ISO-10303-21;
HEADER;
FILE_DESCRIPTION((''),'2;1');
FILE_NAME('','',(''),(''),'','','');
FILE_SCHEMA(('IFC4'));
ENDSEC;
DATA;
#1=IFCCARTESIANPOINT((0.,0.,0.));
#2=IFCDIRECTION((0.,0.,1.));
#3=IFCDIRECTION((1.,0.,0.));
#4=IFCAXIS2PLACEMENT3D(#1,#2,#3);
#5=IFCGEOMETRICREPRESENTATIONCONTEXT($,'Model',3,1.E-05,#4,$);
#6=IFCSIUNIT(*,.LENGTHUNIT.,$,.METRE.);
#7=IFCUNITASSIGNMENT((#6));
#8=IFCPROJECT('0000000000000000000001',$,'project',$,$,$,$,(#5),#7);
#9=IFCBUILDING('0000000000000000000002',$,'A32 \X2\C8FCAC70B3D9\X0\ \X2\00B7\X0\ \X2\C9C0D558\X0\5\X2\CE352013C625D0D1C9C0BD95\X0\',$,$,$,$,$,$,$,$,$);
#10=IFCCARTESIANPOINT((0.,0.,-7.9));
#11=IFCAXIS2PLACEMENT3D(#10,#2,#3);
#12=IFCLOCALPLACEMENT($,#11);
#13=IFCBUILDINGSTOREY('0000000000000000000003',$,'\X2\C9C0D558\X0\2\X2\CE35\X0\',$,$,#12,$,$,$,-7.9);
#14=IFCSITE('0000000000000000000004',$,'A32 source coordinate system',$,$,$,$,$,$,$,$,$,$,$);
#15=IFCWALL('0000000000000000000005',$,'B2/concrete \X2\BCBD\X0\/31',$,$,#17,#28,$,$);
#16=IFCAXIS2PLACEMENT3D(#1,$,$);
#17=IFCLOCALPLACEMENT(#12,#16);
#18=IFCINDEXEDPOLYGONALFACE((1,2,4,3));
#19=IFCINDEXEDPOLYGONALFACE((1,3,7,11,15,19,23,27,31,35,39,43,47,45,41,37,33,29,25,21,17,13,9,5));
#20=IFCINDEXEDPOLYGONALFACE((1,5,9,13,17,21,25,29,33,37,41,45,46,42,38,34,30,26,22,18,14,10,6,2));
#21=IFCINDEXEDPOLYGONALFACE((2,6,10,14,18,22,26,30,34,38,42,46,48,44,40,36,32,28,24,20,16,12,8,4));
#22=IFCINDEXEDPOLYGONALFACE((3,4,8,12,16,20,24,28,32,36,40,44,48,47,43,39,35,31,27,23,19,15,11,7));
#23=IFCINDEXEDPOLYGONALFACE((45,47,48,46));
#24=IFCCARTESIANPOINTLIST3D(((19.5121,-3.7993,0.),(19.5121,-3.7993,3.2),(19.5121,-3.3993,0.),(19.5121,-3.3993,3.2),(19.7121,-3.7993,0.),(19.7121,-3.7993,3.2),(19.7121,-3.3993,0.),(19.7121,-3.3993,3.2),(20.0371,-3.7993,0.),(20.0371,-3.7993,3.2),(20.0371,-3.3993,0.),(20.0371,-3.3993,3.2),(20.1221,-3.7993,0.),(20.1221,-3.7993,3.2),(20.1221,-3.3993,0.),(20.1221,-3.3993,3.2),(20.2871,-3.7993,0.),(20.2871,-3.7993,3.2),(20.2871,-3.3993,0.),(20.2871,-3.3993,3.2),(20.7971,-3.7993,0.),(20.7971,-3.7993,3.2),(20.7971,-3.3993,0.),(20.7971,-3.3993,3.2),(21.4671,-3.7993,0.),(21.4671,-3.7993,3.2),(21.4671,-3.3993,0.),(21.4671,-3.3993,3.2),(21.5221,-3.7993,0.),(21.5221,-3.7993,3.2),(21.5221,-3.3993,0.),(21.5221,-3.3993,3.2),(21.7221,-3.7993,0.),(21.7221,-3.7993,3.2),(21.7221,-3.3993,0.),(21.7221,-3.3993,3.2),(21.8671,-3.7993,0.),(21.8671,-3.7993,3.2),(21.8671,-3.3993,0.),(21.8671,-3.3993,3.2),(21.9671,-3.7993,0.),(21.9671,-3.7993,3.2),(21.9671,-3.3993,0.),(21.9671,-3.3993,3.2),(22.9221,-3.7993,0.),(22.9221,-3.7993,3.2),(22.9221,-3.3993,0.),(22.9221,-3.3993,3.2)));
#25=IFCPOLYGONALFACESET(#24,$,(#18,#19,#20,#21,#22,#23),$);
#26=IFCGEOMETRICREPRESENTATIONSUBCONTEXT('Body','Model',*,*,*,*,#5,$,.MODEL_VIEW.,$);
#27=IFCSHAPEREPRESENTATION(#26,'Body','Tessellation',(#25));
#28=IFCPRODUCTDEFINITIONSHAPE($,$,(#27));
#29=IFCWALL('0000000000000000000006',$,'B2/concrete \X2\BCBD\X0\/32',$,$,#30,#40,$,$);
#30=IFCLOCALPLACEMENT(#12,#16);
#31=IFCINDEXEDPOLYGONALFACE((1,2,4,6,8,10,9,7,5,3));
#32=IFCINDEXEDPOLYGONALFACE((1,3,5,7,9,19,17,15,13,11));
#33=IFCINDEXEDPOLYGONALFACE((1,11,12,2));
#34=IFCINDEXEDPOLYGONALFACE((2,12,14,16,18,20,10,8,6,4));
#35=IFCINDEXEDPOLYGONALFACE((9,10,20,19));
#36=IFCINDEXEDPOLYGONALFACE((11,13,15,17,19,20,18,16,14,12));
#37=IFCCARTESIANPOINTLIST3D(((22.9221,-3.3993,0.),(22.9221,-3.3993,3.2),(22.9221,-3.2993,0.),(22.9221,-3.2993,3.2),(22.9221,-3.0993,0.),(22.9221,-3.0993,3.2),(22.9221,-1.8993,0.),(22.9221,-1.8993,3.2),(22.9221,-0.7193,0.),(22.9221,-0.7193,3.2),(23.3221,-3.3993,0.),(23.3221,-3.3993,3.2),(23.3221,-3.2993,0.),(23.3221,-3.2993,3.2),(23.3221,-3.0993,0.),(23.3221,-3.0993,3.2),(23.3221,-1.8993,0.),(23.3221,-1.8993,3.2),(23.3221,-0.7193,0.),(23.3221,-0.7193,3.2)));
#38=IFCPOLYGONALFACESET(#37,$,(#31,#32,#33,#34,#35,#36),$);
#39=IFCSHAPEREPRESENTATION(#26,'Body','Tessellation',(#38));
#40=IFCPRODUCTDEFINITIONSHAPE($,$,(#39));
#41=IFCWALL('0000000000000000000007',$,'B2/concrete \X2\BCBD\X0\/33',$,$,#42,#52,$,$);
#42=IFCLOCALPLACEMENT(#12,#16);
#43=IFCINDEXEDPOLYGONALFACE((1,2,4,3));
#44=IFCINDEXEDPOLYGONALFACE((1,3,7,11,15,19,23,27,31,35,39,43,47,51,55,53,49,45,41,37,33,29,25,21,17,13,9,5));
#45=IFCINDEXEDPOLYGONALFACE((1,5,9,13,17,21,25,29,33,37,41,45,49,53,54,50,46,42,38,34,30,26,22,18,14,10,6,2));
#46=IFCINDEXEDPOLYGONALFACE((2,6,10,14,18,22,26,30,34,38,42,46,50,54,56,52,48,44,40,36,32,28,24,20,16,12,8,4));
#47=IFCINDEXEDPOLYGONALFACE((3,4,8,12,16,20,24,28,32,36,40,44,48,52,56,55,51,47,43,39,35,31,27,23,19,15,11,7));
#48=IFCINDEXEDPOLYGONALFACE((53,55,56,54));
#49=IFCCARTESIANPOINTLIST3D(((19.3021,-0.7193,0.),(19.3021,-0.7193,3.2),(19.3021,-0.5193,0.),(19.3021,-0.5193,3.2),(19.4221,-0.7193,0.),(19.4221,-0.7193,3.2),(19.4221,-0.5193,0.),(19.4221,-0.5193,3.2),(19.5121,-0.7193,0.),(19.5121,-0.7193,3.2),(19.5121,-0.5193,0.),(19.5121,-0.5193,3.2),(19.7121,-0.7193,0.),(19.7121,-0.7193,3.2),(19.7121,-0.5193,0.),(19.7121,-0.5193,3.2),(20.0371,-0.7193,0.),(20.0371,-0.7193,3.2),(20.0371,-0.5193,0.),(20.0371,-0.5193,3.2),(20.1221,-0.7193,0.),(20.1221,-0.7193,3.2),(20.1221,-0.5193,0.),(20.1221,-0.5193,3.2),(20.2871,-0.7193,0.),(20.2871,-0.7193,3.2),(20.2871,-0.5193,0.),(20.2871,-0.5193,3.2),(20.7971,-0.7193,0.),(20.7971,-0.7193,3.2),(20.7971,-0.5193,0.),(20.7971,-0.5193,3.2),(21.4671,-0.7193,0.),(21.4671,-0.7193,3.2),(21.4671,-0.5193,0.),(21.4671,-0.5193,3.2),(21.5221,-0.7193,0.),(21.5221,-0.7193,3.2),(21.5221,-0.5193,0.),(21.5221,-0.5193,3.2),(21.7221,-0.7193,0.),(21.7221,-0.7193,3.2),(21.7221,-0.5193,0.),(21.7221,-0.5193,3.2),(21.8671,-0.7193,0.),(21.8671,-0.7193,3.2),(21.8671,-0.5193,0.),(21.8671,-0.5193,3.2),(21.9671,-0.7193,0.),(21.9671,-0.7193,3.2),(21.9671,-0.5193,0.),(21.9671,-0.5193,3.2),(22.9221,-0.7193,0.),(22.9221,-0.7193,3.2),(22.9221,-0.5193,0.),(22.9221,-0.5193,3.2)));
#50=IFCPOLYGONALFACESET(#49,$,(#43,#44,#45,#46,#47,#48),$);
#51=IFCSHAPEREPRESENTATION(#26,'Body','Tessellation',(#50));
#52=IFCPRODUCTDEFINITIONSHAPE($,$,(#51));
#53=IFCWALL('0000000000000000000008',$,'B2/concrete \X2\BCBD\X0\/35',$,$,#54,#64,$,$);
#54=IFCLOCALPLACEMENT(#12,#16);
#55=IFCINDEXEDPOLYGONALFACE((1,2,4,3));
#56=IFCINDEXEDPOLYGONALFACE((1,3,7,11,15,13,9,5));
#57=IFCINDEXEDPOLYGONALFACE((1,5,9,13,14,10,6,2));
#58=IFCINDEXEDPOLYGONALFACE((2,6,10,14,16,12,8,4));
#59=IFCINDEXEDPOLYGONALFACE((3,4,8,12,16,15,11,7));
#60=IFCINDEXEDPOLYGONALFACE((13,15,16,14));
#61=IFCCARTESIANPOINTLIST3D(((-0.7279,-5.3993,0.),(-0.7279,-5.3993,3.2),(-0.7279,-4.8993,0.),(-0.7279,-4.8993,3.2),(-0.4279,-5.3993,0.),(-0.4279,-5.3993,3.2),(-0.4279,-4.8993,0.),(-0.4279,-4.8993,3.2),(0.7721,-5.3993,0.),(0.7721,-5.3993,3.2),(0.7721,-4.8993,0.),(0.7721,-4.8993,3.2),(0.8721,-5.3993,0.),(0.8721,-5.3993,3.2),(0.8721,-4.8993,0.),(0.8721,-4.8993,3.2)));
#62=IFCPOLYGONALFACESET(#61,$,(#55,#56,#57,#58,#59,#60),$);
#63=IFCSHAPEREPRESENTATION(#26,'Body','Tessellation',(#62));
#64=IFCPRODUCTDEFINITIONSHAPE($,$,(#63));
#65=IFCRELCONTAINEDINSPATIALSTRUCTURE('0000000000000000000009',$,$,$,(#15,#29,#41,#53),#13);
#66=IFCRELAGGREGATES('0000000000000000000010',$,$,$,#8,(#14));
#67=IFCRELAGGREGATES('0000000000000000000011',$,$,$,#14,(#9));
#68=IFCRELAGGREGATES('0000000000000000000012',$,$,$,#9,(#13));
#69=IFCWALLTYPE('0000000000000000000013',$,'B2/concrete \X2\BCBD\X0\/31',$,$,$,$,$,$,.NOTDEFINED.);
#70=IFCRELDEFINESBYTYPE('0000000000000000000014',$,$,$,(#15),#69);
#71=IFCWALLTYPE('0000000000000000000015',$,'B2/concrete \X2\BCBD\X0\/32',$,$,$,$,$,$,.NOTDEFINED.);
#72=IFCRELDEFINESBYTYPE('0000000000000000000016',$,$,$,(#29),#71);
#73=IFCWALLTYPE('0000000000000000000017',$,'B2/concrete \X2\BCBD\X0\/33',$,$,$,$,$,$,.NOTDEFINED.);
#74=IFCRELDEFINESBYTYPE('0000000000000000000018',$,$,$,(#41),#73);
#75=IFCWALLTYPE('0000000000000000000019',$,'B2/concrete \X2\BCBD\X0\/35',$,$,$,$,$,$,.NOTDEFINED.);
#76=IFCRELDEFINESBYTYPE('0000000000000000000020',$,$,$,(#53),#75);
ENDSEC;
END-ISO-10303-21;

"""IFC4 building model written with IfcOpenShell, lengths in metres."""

from ifc_helpers import new_model, si_unit, frame, origin, origin_with_axes, place, context, subcontext, project, spatial, polyline, outline, extrude, source, transform, mapped, type_object, type_shapes, element, save


model = new_model("IFC4")

# Units and contexts
model_context = context("Model", 3, precision=1e-05, world=origin_with_axes())
body_context = subcontext(model_context, "Body", "Model", "MODEL_VIEW")
ifc_project = project(units=[si_unit("LENGTHUNIT", "METRE")], contexts=[model_context])

# Site, building, storey
site = spatial("IfcSite", under=ifc_project, Name="A32 source coordinate system")
building = spatial("IfcBuilding", under=site, Name="A32 주거동 · 지하5층–옥탑지붕")
storey_placement = place(None, frame((0.0, 0.0, -7.9), z_axis=(0.0, 0.0, 1.0), x_axis=(1.0, 0.0, 0.0)))
storey = spatial("IfcBuildingStorey", under=building, at=storey_placement, Name="지하2층", Elevation=-7.9)

# Walls
wall_type_1 = type_object("IfcWallType", Name="B2/concrete 벽/31", PredefinedType="NOTDEFINED")
shared_shape_1 = source(origin(), body_context, "Body", "SweptSolid", [
    extrude(outline(polyline([(20.1221, -3.3993), (20.2871, -3.3993), (20.7971, -3.3993), (21.4671, -3.3993), (21.5221, -3.3993), (21.7221, -3.3993), (21.8671, -3.3993), (21.9671, -3.3993), (22.9221, -3.3993), (22.9221, -3.7993), (21.9671, -3.7993), (21.8671, -3.7993), (21.7221, -3.7993), (21.5221, -3.7993), (21.4671, -3.7993), (20.7971, -3.7993), (20.2871, -3.7993), (20.1221, -3.7993), (20.0371, -3.7993), (19.7121, -3.7993), (19.5121, -3.7993), (19.5121, -3.3993), (19.7121, -3.3993), (20.0371, -3.3993), (20.1221, -3.3993)])), origin(), (0.0, 0.0, 1.0), 3.2),
])
type_shapes(wall_type_1, [shared_shape_1])
wall_1_placement = place(storey_placement, origin_with_axes())
element("IfcWall", 1, at=wall_1_placement, inside=storey, type_object=wall_type_1, Name="B2/concrete 벽/31", context=body_context, shape_type="MappedRepresentation", body=[
    mapped(shared_shape_1, transform((0.0, 0.0, 0.0), scale=1.0)),
])
wall_type_2 = type_object("IfcWallType", Name="B2/concrete 벽/32", PredefinedType="NOTDEFINED")
shared_shape_2 = source(origin(), body_context, "Body", "SweptSolid", [
    extrude(outline(polyline([(22.9221, -1.8993), (22.9221, -0.7193), (23.3221, -0.7193), (23.3221, -1.8993), (23.3221, -3.0993), (23.3221, -3.2993), (23.3221, -3.3993), (22.9221, -3.3993), (22.9221, -3.2993), (22.9221, -3.0993), (22.9221, -1.8993)])), origin(), (0.0, 0.0, 1.0), 3.2),
])
type_shapes(wall_type_2, [shared_shape_2])
wall_2_placement = place(storey_placement, origin_with_axes())
element("IfcWall", 2, at=wall_2_placement, inside=storey, type_object=wall_type_2, Name="B2/concrete 벽/32", context=body_context, shape_type="MappedRepresentation", body=[
    mapped(shared_shape_2, transform((0.0, 0.0, 0.0), scale=1.0)),
])
wall_type_3 = type_object("IfcWallType", Name="B2/concrete 벽/33", PredefinedType="NOTDEFINED")
shared_shape_3 = source(origin(), body_context, "Body", "SweptSolid", [
    extrude(outline(polyline([(21.7221, -0.7193), (21.5221, -0.7193), (21.4671, -0.7193), (20.7971, -0.7193), (20.2871, -0.7193), (20.1221, -0.7193), (20.0371, -0.7193), (19.7121, -0.7193), (19.5121, -0.7193), (19.4221, -0.7193), (19.3021, -0.7193), (19.3021, -0.5193), (19.4221, -0.5193), (19.5121, -0.5193), (19.7121, -0.5193), (20.0371, -0.5193), (20.1221, -0.5193), (20.2871, -0.5193), (20.7971, -0.5193), (21.4671, -0.5193), (21.5221, -0.5193), (21.7221, -0.5193), (21.8671, -0.5193), (21.9671, -0.5193), (22.9221, -0.5193), (22.9221, -0.7193), (21.9671, -0.7193), (21.8671, -0.7193), (21.7221, -0.7193)])), origin(), (0.0, 0.0, 1.0), 3.2),
])
type_shapes(wall_type_3, [shared_shape_3])
wall_3_placement = place(storey_placement, origin_with_axes())
element("IfcWall", 3, at=wall_3_placement, inside=storey, type_object=wall_type_3, Name="B2/concrete 벽/33", context=body_context, shape_type="MappedRepresentation", body=[
    mapped(shared_shape_3, transform((0.0, 0.0, 0.0), scale=1.0)),
])
wall_type_4 = type_object("IfcWallType", Name="B2/concrete 벽/35", PredefinedType="NOTDEFINED")
shared_shape_4 = source(origin(), body_context, "Body", "SweptSolid", [
    extrude(outline(polyline([(0.7721, -4.8993), (0.8721, -4.8993), (0.8721, -5.3993), (0.7721, -5.3993), (-0.4279, -5.3993), (-0.7279, -5.3993), (-0.7279, -4.8993), (-0.4279, -4.8993), (0.7721, -4.8993)])), origin(), (0.0, 0.0, 1.0), 3.2),
])
type_shapes(wall_type_4, [shared_shape_4])
wall_4_placement = place(storey_placement, origin_with_axes())
element("IfcWall", 4, at=wall_4_placement, inside=storey, type_object=wall_type_4, Name="B2/concrete 벽/35", context=body_context, shape_type="MappedRepresentation", body=[
    mapped(shared_shape_4, transform((0.0, 0.0, 0.0), scale=1.0)),
])

save(model, "model.ifc")
